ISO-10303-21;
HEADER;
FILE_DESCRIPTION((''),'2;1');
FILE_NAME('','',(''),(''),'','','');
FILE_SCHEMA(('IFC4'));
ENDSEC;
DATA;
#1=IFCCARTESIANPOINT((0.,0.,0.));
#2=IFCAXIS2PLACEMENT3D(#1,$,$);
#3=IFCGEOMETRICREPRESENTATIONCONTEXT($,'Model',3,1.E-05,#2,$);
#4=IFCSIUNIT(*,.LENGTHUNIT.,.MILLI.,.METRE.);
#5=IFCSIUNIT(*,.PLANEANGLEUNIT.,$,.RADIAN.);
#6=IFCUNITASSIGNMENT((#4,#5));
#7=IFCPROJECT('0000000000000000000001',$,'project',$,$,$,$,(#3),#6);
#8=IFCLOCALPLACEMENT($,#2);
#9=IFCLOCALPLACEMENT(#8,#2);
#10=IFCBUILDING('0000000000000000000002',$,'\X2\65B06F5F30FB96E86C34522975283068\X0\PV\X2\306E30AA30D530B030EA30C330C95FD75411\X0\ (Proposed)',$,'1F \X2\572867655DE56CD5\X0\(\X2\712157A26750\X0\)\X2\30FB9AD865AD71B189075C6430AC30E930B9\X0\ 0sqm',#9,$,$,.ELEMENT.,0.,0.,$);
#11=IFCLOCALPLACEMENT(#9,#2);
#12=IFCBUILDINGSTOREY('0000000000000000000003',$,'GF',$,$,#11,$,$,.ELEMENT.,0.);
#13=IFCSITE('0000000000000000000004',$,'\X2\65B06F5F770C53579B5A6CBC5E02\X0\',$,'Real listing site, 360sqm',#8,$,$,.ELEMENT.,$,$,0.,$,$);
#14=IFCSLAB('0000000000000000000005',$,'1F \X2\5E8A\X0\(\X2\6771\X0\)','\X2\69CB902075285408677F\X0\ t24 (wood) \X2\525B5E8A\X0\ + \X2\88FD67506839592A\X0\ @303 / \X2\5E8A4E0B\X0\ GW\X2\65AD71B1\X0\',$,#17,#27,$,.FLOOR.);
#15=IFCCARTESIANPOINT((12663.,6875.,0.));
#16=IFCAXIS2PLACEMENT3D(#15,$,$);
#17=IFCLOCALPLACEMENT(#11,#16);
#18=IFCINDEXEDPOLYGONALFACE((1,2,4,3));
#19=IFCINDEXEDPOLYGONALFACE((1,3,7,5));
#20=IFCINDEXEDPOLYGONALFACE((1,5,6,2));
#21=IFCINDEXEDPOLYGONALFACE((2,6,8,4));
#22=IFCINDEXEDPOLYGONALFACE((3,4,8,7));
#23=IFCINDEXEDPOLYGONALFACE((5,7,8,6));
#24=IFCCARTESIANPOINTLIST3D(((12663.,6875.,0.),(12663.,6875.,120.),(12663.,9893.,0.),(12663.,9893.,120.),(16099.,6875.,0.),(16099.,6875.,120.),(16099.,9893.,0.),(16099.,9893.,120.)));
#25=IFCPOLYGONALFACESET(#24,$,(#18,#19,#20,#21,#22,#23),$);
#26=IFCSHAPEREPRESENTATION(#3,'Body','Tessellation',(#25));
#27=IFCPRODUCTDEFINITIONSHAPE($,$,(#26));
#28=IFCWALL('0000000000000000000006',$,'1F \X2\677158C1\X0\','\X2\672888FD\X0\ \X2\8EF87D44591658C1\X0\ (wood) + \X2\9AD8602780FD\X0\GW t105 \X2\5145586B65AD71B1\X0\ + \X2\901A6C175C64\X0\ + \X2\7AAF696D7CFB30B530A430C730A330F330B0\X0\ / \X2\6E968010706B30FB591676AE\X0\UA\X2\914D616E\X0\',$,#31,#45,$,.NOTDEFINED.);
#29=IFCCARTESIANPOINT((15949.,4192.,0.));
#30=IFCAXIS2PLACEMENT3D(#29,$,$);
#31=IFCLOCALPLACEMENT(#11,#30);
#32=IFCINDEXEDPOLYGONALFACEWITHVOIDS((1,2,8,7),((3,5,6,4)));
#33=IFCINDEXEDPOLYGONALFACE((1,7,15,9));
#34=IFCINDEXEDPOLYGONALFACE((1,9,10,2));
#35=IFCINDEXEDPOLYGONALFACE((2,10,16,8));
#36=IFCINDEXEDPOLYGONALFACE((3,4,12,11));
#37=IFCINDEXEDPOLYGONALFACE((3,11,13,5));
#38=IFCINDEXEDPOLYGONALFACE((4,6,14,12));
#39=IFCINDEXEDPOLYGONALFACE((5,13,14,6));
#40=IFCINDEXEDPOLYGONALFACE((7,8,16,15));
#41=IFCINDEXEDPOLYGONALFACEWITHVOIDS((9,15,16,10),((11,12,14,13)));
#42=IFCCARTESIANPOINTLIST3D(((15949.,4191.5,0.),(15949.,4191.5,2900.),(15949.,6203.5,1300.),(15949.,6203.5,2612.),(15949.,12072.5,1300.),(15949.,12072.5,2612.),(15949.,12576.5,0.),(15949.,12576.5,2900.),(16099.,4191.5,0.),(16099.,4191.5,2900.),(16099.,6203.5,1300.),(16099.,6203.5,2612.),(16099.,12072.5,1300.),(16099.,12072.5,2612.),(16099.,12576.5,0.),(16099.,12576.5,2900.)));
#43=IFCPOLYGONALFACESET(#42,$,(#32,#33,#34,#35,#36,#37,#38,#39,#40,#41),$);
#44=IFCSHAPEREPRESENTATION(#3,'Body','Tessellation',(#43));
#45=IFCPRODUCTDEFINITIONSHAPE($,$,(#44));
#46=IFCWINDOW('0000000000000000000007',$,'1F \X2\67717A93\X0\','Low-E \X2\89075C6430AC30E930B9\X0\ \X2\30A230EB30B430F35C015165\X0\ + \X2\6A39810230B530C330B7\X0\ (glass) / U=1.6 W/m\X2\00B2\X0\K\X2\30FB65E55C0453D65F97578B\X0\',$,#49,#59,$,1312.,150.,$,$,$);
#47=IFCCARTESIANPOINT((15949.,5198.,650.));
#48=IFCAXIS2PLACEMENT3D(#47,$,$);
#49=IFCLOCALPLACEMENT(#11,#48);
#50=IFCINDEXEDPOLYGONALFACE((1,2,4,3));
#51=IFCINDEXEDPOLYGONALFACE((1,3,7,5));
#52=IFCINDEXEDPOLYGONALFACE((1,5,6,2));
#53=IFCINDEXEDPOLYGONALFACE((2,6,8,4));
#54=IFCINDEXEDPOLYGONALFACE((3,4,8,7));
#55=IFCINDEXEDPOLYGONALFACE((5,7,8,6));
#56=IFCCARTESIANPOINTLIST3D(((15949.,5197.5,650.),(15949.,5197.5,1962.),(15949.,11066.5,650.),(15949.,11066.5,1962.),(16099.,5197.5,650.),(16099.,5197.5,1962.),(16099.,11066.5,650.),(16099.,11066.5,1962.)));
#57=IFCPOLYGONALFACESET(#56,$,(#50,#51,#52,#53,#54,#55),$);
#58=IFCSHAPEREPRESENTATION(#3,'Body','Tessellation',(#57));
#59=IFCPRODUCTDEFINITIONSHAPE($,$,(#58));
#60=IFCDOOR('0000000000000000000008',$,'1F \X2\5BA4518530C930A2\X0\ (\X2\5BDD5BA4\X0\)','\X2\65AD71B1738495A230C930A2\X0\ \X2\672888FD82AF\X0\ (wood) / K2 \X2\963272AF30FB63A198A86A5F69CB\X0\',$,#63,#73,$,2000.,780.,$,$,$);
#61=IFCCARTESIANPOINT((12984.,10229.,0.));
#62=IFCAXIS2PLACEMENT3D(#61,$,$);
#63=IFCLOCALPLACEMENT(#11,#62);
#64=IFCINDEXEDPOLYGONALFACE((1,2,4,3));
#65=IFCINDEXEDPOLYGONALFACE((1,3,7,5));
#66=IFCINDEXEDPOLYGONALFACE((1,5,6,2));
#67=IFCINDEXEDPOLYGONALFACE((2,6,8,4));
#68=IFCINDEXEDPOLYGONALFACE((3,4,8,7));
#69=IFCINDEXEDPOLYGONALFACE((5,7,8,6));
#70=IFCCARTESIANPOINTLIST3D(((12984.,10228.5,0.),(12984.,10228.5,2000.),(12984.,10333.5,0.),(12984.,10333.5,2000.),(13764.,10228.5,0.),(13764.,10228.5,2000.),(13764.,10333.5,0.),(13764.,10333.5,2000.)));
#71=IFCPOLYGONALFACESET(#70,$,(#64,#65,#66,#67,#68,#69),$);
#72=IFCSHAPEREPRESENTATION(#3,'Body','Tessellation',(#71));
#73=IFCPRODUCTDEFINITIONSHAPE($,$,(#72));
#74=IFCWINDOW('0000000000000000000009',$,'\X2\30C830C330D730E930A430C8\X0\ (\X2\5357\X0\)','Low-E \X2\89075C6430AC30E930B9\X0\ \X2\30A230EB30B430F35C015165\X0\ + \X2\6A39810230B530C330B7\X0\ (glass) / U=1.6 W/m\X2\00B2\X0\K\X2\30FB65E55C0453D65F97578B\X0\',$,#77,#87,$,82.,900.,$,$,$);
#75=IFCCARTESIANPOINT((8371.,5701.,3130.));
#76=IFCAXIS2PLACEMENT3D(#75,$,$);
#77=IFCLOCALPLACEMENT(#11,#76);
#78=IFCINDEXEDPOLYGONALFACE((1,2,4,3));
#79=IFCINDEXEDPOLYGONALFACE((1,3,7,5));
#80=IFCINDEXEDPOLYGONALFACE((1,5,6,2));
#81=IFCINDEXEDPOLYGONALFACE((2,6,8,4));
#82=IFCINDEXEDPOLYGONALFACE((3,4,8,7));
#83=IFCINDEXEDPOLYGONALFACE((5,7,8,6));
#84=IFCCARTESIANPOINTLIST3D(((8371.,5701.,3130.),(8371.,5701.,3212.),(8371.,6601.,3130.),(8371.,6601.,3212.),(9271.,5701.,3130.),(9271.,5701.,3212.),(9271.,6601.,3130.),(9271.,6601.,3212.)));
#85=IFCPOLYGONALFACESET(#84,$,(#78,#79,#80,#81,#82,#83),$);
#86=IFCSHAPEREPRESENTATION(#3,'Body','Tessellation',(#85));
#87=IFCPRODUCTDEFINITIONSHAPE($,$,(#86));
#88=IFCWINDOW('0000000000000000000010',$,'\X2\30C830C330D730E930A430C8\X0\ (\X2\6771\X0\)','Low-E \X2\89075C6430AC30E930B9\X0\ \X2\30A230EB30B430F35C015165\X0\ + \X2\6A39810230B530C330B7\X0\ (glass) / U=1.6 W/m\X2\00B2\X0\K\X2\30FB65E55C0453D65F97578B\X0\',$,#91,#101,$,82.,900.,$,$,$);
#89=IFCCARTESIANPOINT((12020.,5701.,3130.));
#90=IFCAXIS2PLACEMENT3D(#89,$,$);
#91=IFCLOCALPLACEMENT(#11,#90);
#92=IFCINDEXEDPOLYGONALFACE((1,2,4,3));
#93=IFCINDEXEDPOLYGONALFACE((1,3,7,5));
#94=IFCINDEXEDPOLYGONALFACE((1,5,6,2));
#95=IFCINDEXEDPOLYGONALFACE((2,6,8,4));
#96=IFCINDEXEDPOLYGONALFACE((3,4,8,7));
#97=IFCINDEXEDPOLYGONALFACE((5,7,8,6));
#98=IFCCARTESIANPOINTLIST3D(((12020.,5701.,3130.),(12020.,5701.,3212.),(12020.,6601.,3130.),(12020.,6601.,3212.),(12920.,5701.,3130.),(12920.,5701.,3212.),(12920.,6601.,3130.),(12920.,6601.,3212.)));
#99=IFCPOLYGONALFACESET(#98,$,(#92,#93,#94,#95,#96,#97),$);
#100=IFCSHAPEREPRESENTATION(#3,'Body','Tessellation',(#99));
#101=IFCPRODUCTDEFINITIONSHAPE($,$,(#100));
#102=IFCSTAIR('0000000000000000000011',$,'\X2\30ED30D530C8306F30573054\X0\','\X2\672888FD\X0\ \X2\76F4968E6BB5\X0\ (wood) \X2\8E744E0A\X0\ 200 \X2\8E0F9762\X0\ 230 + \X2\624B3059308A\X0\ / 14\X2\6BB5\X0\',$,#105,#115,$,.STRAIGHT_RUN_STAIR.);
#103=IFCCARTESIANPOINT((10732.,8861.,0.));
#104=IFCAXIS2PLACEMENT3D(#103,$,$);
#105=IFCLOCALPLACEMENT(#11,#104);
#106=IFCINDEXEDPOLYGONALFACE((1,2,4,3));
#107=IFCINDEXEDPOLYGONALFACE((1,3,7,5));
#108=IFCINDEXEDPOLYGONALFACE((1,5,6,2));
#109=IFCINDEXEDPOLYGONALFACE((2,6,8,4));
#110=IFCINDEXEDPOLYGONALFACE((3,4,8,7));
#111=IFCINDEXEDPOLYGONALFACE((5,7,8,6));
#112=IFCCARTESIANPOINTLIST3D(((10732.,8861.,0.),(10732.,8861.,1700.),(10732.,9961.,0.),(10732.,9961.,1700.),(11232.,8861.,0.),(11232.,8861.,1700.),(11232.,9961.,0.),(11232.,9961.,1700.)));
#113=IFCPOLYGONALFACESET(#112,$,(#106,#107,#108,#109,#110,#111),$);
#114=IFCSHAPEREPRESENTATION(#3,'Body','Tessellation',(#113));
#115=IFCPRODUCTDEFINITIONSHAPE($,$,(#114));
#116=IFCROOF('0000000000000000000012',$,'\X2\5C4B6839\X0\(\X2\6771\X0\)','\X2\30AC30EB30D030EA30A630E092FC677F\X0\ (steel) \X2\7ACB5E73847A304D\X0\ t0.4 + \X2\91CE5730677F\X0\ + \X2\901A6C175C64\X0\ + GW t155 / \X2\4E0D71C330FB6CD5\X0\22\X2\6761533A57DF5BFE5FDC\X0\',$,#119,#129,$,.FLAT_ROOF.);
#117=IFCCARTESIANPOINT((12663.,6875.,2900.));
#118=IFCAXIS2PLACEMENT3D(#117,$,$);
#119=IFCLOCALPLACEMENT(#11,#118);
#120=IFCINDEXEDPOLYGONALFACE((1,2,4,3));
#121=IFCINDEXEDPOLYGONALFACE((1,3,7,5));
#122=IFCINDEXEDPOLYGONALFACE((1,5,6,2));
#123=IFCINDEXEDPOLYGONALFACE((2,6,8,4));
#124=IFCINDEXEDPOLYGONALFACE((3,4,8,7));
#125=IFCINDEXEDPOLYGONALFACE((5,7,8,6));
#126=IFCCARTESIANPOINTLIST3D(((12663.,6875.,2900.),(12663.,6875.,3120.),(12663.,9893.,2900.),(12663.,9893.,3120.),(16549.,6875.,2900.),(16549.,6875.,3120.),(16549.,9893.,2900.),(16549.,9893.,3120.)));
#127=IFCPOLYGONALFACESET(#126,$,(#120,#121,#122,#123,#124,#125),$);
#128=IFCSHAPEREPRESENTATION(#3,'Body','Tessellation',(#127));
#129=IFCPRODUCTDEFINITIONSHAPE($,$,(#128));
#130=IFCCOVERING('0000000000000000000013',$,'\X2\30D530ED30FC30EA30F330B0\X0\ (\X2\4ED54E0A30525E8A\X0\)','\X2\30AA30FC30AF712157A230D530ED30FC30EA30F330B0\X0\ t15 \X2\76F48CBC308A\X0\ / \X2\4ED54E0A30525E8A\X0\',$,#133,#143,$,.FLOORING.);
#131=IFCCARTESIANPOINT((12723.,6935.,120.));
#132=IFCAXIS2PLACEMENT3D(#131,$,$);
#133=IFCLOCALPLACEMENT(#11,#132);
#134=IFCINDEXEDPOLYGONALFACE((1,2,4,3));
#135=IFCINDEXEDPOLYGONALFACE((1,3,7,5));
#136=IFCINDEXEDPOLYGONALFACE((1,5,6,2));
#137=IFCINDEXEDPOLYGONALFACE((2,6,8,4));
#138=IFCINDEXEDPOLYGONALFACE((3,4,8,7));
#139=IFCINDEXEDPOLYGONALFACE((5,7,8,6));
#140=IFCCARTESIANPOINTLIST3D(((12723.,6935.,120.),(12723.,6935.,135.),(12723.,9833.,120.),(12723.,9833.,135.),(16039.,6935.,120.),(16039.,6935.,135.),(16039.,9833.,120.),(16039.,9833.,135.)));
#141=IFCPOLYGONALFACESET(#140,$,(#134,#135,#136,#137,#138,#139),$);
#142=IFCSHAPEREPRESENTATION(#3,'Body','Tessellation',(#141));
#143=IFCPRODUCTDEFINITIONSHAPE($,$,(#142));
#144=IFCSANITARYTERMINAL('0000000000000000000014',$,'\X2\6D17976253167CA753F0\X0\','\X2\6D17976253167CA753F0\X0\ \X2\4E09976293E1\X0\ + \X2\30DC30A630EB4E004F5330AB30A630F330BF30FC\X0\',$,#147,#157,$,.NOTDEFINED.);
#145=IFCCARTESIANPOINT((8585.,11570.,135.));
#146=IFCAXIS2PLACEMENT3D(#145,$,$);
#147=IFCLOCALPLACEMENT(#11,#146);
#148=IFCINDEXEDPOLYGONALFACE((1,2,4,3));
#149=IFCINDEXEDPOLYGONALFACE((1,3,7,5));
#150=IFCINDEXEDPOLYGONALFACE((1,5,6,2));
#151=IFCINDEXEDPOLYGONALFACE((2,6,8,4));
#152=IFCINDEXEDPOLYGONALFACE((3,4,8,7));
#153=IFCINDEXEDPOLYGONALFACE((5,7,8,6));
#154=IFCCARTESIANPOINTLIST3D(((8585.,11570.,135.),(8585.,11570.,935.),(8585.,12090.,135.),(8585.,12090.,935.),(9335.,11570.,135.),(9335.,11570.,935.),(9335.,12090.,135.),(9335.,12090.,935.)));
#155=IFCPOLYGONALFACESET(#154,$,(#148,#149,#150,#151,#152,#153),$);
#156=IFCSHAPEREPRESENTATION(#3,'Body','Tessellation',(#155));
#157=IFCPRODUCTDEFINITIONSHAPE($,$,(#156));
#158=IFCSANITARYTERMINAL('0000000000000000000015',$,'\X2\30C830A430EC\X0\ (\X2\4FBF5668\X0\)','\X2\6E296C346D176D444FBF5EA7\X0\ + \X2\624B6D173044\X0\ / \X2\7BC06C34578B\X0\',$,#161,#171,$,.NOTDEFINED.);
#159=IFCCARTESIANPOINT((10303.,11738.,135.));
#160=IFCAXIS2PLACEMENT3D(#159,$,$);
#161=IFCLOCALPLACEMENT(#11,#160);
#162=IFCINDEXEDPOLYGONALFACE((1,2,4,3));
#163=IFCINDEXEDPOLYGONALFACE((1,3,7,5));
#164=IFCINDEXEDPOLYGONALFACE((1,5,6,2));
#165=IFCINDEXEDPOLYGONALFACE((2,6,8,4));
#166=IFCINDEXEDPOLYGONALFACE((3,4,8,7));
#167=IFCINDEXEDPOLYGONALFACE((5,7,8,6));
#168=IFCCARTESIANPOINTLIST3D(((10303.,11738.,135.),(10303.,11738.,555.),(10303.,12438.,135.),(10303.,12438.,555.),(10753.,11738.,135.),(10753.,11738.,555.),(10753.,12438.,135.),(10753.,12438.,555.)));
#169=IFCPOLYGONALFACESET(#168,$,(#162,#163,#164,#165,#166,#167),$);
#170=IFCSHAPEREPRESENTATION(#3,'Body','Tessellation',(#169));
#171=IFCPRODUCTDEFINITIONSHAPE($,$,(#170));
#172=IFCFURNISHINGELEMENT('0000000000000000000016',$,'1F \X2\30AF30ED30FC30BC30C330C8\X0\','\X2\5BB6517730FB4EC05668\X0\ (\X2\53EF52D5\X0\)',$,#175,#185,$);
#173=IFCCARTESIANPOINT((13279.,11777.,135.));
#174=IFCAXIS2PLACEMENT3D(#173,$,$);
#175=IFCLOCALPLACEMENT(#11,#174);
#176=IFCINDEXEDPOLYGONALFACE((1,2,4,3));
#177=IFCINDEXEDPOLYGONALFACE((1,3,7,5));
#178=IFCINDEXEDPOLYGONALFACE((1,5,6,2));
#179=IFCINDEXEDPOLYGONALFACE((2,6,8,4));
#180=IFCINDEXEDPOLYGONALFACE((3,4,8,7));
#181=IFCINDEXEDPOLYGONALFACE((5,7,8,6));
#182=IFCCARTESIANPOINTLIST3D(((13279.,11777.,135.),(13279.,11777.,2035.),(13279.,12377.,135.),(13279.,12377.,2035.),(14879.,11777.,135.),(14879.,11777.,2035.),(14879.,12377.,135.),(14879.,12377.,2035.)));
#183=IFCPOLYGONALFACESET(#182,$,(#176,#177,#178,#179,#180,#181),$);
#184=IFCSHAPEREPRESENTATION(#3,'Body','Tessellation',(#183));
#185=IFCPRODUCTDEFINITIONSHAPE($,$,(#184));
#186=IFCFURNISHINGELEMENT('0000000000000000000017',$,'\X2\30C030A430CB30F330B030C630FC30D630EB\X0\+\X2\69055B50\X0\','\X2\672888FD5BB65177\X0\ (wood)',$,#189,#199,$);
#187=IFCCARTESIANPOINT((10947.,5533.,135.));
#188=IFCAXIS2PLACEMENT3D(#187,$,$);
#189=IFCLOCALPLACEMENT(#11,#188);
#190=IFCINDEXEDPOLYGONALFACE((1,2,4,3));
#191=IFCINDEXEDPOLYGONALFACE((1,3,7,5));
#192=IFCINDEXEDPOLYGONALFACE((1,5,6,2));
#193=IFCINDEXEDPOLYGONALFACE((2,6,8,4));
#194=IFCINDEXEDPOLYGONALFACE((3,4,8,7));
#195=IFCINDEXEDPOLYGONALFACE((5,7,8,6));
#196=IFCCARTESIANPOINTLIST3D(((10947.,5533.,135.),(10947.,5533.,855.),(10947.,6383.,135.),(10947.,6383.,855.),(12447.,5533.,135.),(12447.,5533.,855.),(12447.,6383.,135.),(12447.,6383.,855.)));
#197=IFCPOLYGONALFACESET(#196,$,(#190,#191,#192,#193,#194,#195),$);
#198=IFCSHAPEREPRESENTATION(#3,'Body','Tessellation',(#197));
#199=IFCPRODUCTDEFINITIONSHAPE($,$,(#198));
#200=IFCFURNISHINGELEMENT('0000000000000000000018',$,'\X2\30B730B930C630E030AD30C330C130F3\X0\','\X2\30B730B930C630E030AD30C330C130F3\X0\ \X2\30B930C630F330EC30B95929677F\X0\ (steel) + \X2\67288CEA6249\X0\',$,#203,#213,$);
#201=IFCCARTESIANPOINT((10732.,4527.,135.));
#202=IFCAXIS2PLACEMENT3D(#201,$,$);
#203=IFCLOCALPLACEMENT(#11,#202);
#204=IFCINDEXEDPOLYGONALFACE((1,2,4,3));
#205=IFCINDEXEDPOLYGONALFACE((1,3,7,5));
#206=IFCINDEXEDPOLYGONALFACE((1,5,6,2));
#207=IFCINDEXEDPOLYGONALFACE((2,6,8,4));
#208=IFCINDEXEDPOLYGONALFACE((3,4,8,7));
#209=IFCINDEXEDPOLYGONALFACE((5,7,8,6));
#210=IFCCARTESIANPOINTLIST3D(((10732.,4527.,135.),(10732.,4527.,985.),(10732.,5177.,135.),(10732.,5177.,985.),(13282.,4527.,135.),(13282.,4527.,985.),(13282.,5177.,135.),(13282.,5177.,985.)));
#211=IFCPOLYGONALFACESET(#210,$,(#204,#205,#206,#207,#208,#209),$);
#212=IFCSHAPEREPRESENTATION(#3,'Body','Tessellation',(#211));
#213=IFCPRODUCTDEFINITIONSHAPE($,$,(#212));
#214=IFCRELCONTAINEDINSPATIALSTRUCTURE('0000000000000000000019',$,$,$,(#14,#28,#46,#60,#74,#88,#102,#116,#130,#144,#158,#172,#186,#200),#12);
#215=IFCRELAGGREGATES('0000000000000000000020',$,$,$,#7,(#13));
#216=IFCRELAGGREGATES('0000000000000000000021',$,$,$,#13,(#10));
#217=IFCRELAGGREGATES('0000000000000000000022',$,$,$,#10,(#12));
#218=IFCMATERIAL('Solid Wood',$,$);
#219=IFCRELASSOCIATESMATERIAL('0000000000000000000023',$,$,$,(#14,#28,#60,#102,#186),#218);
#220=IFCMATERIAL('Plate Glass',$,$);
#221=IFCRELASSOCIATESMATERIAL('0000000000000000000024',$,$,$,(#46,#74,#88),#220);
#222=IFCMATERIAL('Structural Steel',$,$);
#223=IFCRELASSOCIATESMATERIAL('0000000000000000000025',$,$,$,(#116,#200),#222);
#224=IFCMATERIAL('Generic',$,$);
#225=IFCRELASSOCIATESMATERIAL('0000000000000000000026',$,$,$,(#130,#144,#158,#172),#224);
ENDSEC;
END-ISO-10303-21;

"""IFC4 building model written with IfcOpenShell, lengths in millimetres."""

from ifc_helpers import new_model, si_unit, frame, frame_2d, origin, place, context, project, spatial, rectangle, extrude, material, element, fill, save


model = new_model("IFC4")

# Units and contexts
model_context = context("Model", 3, precision=1e-05, world=origin())
ifc_project = project(units=[si_unit("LENGTHUNIT", "METRE", prefix="MILLI"), si_unit("PLANEANGLEUNIT", "RADIAN")], contexts=[model_context])

# Site, building, storey
site_placement = place(None, origin())
site = spatial("IfcSite", under=ifc_project, at=site_placement, Name="新潟県南魚沼市", ObjectType="Real listing site, 360sqm", CompositionType="ELEMENT", RefElevation=0.0)
building_placement = place(site_placement, origin())
building = spatial("IfcBuilding", under=site, at=building_placement, Name="新潟・雨水利用とPVのオフグリッド志向 (Proposed)", ObjectType="1F 在来工法(無垢材)・高断熱複層ガラス 0sqm", CompositionType="ELEMENT", ElevationOfRefHeight=0.0, ElevationOfTerrain=0.0)
storey_placement = place(building_placement, origin())
storey = spatial("IfcBuildingStorey", under=building, at=storey_placement, Name="GF", CompositionType="ELEMENT", Elevation=0.0)

# Slab
ifc_material_1 = material(Name="Solid Wood")
slab_1_placement = place(storey_placement, frame((12663.0, 6875.0, 0.0)))
element("IfcSlab", 1, at=slab_1_placement, inside=storey, material=ifc_material_1, Name="1F 床(東)", Description="構造用合板 t24 (wood) 剛床 + 製材根太 @303 / 床下 GW断熱", PredefinedType="FLOOR", context=model_context, shape_type="SweptSolid", body=[
    extrude(rectangle(XDim=3436.0, YDim=3018.0, at=frame_2d((1718.0, 1509.0))), frame((12663.0, 6875.0, 0.0)), (0.0, 0.0, 1.0), 120.0),
])

# Wall, opening, window
wall_1_placement = place(storey_placement, frame((15949.0, 4192.0, 0.0)))
wall_1 = element("IfcWall", 2, at=wall_1_placement, inside=storey, material=ifc_material_1, Name="1F 東壁", Description="木製 軸組外壁 (wood) + 高性能GW t105 充填断熱 + 通気層 + 窯業系サイディング / 準耐火・外皮UA配慮", PredefinedType="NOTDEFINED", context=model_context, shape_type="SweptSolid", body=[
    extrude(rectangle(XDim=150.0, YDim=8385.0, at=frame_2d((75.0, 4192.0))), frame((15949.0, 4192.0, 0.0)), (0.0, 0.0, 1.0), 2900.0),
])
opening_1_placement = place(storey_placement, frame((15949.0, 5198.0, 650.0)))
opening_1 = element("IfcOpeningElement", 3, at=opening_1_placement, cuts=wall_1, PredefinedType="NOTDEFINED", context=model_context, shape_type="SweptSolid", body=[
    extrude(rectangle(XDim=150.0, YDim=5869.0, at=frame_2d((75.0, 2934.0))), frame((15949.0, 5198.0, 650.0)), (0.0, 0.0, 1.0), 1312.0),
])
ifc_material_2 = material(Name="Plate Glass")
window_1_placement = place(storey_placement, frame((15949.0, 5198.0, 650.0)))
window_1 = element("IfcWindow", 4, at=window_1_placement, inside=storey, material=ifc_material_2, Name="1F 東窓", Description="Low-E 複層ガラス アルゴン封入 + 樹脂サッシ (glass) / U=1.6 W/m²K・日射取得型", OverallHeight=1312.0, OverallWidth=150.0, context=model_context, shape_type="SweptSolid", body=[
    extrude(rectangle(XDim=150.0, YDim=5869.0, at=frame_2d((75.0, 2934.0))), frame((15949.0, 5198.0, 650.0)), (0.0, 0.0, 1.0), 1312.0),
])
fill(opening_1, window_1)

# Door
door_placement = place(storey_placement, frame((12984.0, 10229.0, 0.0)))
element("IfcDoor", 5, at=door_placement, inside=storey, material=ifc_material_1, Name="1F 室内ドア (寝室)", Description="断熱玄関ドア 木製芯 (wood) / K2 防犯・採風機構", OverallHeight=2000.0, OverallWidth=780.0, context=model_context, shape_type="SweptSolid", body=[
    extrude(rectangle(XDim=780.0, YDim=105.0, at=frame_2d((390.0, 52.0))), frame((12984.0, 10229.0, 0.0)), (0.0, 0.0, 1.0), 2000.0),
])

# Windows
window_2_placement = place(storey_placement, frame((8371.0, 5701.0, 3130.0)))
element("IfcWindow", 6, at=window_2_placement, inside=storey, material=ifc_material_2, Name="トップライト (南)", Description="Low-E 複層ガラス アルゴン封入 + 樹脂サッシ (glass) / U=1.6 W/m²K・日射取得型", OverallHeight=82.0, OverallWidth=900.0, context=model_context, shape_type="SweptSolid", body=[
    extrude(rectangle(XDim=900.0, YDim=900.0, at=frame_2d((450.0, 450.0))), frame((8371.0, 5701.0, 3130.0)), (0.0, 0.0, 1.0), 82.0),
])
window_3_placement = place(storey_placement, frame((12020.0, 5701.0, 3130.0)))
element("IfcWindow", 7, at=window_3_placement, inside=storey, material=ifc_material_2, Name="トップライト (東)", Description="Low-E 複層ガラス アルゴン封入 + 樹脂サッシ (glass) / U=1.6 W/m²K・日射取得型", OverallHeight=82.0, OverallWidth=900.0, context=model_context, shape_type="SweptSolid", body=[
    extrude(rectangle(XDim=900.0, YDim=900.0, at=frame_2d((450.0, 450.0))), frame((12020.0, 5701.0, 3130.0)), (0.0, 0.0, 1.0), 82.0),
])

# Stair
stair_placement = place(storey_placement, frame((10732.0, 8861.0, 0.0)))
element("IfcStair", 8, at=stair_placement, inside=storey, material=ifc_material_1, Name="ロフトはしご", Description="木製 直階段 (wood) 蹴上 200 踏面 230 + 手すり / 14段", PredefinedType="STRAIGHT_RUN_STAIR", context=model_context, shape_type="SweptSolid", body=[
    extrude(rectangle(XDim=500.0, YDim=1100.0, at=frame_2d((250.0, 550.0))), frame((10732.0, 8861.0, 0.0)), (0.0, 0.0, 1.0), 1700.0),
])

# Roof
ifc_material_3 = material(Name="Structural Steel")
roof_placement = place(storey_placement, frame((12663.0, 6875.0, 2900.0)))
element("IfcRoof", 9, at=roof_placement, inside=storey, material=ifc_material_3, Name="屋根(東)", Description="ガルバリウム鋼板 (steel) 立平葺き t0.4 + 野地板 + 通気層 + GW t155 / 不燃・法22条区域対応", PredefinedType="FLAT_ROOF", context=model_context, shape_type="SweptSolid", body=[
    extrude(rectangle(XDim=3886.0, YDim=3018.0, at=frame_2d((1943.0, 1509.0))), frame((12663.0, 6875.0, 2900.0)), (0.0, 0.0, 1.0), 220.0),
])

# Covering
ifc_material_4 = material(Name="Generic")
covering_placement = place(storey_placement, frame((12723.0, 6935.0, 120.0)))
element("IfcCovering", 10, at=covering_placement, inside=storey, material=ifc_material_4, Name="フローリング (仕上げ床)", Description="オーク無垢フローリング t15 直貼り / 仕上げ床", PredefinedType="FLOORING", context=model_context, shape_type="SweptSolid", body=[
    extrude(rectangle(XDim=3316.0, YDim=2898.0, at=frame_2d((1658.0, 1449.0))), frame((12723.0, 6935.0, 120.0)), (0.0, 0.0, 1.0), 15.0),
])

# Sanitary terminals
sanitary_terminal_1_placement = place(storey_placement, frame((8585.0, 11570.0, 135.0)))
element("IfcSanitaryTerminal", 11, at=sanitary_terminal_1_placement, inside=storey, material=ifc_material_4, Name="洗面化粧台", Description="洗面化粧台 三面鏡 + ボウル一体カウンター", PredefinedType="NOTDEFINED", context=model_context, shape_type="SweptSolid", body=[
    extrude(rectangle(XDim=750.0, YDim=520.0, at=frame_2d((375.0, 260.0))), frame((8585.0, 11570.0, 135.0)), (0.0, 0.0, 1.0), 800.0),
])
sanitary_terminal_2_placement = place(storey_placement, frame((10303.0, 11738.0, 135.0)))
element("IfcSanitaryTerminal", 12, at=sanitary_terminal_2_placement, inside=storey, material=ifc_material_4, Name="トイレ (便器)", Description="温水洗浄便座 + 手洗い / 節水型", PredefinedType="NOTDEFINED", context=model_context, shape_type="SweptSolid", body=[
    extrude(rectangle(XDim=450.0, YDim=700.0, at=frame_2d((225.0, 350.0))), frame((10303.0, 11738.0, 135.0)), (0.0, 0.0, 1.0), 420.0),
])

# Furnishing elements
furnishing_1_placement = place(storey_placement, frame((13279.0, 11777.0, 135.0)))
element("IfcFurnishingElement", 13, at=furnishing_1_placement, inside=storey, material=ifc_material_4, Name="1F クローゼット", Description="家具・什器 (可動)", context=model_context, shape_type="SweptSolid", body=[
    extrude(rectangle(XDim=1600.0, YDim=600.0, at=frame_2d((800.0, 300.0))), frame((13279.0, 11777.0, 135.0)), (0.0, 0.0, 1.0), 1900.0),
])
furnishing_2_placement = place(storey_placement, frame((10947.0, 5533.0, 135.0)))
element("IfcFurnishingElement", 14, at=furnishing_2_placement, inside=storey, material=ifc_material_1, Name="ダイニングテーブル+椅子", Description="木製家具 (wood)", context=model_context, shape_type="SweptSolid", body=[
    extrude(rectangle(XDim=1500.0, YDim=850.0, at=frame_2d((750.0, 425.0))), frame((10947.0, 5533.0, 135.0)), (0.0, 0.0, 1.0), 720.0),
])
furnishing_3_placement = place(storey_placement, frame((10732.0, 4527.0, 135.0)))
element("IfcFurnishingElement", 15, at=furnishing_3_placement, inside=storey, material=ifc_material_3, Name="システムキッチン", Description="システムキッチン ステンレス天板 (steel) + 木質扉", context=model_context, shape_type="SweptSolid", body=[
    extrude(rectangle(XDim=2550.0, YDim=650.0, at=frame_2d((1275.0, 325.0))), frame((10732.0, 4527.0, 135.0)), (0.0, 0.0, 1.0), 850.0),
])

save(model, "model.ifc")
